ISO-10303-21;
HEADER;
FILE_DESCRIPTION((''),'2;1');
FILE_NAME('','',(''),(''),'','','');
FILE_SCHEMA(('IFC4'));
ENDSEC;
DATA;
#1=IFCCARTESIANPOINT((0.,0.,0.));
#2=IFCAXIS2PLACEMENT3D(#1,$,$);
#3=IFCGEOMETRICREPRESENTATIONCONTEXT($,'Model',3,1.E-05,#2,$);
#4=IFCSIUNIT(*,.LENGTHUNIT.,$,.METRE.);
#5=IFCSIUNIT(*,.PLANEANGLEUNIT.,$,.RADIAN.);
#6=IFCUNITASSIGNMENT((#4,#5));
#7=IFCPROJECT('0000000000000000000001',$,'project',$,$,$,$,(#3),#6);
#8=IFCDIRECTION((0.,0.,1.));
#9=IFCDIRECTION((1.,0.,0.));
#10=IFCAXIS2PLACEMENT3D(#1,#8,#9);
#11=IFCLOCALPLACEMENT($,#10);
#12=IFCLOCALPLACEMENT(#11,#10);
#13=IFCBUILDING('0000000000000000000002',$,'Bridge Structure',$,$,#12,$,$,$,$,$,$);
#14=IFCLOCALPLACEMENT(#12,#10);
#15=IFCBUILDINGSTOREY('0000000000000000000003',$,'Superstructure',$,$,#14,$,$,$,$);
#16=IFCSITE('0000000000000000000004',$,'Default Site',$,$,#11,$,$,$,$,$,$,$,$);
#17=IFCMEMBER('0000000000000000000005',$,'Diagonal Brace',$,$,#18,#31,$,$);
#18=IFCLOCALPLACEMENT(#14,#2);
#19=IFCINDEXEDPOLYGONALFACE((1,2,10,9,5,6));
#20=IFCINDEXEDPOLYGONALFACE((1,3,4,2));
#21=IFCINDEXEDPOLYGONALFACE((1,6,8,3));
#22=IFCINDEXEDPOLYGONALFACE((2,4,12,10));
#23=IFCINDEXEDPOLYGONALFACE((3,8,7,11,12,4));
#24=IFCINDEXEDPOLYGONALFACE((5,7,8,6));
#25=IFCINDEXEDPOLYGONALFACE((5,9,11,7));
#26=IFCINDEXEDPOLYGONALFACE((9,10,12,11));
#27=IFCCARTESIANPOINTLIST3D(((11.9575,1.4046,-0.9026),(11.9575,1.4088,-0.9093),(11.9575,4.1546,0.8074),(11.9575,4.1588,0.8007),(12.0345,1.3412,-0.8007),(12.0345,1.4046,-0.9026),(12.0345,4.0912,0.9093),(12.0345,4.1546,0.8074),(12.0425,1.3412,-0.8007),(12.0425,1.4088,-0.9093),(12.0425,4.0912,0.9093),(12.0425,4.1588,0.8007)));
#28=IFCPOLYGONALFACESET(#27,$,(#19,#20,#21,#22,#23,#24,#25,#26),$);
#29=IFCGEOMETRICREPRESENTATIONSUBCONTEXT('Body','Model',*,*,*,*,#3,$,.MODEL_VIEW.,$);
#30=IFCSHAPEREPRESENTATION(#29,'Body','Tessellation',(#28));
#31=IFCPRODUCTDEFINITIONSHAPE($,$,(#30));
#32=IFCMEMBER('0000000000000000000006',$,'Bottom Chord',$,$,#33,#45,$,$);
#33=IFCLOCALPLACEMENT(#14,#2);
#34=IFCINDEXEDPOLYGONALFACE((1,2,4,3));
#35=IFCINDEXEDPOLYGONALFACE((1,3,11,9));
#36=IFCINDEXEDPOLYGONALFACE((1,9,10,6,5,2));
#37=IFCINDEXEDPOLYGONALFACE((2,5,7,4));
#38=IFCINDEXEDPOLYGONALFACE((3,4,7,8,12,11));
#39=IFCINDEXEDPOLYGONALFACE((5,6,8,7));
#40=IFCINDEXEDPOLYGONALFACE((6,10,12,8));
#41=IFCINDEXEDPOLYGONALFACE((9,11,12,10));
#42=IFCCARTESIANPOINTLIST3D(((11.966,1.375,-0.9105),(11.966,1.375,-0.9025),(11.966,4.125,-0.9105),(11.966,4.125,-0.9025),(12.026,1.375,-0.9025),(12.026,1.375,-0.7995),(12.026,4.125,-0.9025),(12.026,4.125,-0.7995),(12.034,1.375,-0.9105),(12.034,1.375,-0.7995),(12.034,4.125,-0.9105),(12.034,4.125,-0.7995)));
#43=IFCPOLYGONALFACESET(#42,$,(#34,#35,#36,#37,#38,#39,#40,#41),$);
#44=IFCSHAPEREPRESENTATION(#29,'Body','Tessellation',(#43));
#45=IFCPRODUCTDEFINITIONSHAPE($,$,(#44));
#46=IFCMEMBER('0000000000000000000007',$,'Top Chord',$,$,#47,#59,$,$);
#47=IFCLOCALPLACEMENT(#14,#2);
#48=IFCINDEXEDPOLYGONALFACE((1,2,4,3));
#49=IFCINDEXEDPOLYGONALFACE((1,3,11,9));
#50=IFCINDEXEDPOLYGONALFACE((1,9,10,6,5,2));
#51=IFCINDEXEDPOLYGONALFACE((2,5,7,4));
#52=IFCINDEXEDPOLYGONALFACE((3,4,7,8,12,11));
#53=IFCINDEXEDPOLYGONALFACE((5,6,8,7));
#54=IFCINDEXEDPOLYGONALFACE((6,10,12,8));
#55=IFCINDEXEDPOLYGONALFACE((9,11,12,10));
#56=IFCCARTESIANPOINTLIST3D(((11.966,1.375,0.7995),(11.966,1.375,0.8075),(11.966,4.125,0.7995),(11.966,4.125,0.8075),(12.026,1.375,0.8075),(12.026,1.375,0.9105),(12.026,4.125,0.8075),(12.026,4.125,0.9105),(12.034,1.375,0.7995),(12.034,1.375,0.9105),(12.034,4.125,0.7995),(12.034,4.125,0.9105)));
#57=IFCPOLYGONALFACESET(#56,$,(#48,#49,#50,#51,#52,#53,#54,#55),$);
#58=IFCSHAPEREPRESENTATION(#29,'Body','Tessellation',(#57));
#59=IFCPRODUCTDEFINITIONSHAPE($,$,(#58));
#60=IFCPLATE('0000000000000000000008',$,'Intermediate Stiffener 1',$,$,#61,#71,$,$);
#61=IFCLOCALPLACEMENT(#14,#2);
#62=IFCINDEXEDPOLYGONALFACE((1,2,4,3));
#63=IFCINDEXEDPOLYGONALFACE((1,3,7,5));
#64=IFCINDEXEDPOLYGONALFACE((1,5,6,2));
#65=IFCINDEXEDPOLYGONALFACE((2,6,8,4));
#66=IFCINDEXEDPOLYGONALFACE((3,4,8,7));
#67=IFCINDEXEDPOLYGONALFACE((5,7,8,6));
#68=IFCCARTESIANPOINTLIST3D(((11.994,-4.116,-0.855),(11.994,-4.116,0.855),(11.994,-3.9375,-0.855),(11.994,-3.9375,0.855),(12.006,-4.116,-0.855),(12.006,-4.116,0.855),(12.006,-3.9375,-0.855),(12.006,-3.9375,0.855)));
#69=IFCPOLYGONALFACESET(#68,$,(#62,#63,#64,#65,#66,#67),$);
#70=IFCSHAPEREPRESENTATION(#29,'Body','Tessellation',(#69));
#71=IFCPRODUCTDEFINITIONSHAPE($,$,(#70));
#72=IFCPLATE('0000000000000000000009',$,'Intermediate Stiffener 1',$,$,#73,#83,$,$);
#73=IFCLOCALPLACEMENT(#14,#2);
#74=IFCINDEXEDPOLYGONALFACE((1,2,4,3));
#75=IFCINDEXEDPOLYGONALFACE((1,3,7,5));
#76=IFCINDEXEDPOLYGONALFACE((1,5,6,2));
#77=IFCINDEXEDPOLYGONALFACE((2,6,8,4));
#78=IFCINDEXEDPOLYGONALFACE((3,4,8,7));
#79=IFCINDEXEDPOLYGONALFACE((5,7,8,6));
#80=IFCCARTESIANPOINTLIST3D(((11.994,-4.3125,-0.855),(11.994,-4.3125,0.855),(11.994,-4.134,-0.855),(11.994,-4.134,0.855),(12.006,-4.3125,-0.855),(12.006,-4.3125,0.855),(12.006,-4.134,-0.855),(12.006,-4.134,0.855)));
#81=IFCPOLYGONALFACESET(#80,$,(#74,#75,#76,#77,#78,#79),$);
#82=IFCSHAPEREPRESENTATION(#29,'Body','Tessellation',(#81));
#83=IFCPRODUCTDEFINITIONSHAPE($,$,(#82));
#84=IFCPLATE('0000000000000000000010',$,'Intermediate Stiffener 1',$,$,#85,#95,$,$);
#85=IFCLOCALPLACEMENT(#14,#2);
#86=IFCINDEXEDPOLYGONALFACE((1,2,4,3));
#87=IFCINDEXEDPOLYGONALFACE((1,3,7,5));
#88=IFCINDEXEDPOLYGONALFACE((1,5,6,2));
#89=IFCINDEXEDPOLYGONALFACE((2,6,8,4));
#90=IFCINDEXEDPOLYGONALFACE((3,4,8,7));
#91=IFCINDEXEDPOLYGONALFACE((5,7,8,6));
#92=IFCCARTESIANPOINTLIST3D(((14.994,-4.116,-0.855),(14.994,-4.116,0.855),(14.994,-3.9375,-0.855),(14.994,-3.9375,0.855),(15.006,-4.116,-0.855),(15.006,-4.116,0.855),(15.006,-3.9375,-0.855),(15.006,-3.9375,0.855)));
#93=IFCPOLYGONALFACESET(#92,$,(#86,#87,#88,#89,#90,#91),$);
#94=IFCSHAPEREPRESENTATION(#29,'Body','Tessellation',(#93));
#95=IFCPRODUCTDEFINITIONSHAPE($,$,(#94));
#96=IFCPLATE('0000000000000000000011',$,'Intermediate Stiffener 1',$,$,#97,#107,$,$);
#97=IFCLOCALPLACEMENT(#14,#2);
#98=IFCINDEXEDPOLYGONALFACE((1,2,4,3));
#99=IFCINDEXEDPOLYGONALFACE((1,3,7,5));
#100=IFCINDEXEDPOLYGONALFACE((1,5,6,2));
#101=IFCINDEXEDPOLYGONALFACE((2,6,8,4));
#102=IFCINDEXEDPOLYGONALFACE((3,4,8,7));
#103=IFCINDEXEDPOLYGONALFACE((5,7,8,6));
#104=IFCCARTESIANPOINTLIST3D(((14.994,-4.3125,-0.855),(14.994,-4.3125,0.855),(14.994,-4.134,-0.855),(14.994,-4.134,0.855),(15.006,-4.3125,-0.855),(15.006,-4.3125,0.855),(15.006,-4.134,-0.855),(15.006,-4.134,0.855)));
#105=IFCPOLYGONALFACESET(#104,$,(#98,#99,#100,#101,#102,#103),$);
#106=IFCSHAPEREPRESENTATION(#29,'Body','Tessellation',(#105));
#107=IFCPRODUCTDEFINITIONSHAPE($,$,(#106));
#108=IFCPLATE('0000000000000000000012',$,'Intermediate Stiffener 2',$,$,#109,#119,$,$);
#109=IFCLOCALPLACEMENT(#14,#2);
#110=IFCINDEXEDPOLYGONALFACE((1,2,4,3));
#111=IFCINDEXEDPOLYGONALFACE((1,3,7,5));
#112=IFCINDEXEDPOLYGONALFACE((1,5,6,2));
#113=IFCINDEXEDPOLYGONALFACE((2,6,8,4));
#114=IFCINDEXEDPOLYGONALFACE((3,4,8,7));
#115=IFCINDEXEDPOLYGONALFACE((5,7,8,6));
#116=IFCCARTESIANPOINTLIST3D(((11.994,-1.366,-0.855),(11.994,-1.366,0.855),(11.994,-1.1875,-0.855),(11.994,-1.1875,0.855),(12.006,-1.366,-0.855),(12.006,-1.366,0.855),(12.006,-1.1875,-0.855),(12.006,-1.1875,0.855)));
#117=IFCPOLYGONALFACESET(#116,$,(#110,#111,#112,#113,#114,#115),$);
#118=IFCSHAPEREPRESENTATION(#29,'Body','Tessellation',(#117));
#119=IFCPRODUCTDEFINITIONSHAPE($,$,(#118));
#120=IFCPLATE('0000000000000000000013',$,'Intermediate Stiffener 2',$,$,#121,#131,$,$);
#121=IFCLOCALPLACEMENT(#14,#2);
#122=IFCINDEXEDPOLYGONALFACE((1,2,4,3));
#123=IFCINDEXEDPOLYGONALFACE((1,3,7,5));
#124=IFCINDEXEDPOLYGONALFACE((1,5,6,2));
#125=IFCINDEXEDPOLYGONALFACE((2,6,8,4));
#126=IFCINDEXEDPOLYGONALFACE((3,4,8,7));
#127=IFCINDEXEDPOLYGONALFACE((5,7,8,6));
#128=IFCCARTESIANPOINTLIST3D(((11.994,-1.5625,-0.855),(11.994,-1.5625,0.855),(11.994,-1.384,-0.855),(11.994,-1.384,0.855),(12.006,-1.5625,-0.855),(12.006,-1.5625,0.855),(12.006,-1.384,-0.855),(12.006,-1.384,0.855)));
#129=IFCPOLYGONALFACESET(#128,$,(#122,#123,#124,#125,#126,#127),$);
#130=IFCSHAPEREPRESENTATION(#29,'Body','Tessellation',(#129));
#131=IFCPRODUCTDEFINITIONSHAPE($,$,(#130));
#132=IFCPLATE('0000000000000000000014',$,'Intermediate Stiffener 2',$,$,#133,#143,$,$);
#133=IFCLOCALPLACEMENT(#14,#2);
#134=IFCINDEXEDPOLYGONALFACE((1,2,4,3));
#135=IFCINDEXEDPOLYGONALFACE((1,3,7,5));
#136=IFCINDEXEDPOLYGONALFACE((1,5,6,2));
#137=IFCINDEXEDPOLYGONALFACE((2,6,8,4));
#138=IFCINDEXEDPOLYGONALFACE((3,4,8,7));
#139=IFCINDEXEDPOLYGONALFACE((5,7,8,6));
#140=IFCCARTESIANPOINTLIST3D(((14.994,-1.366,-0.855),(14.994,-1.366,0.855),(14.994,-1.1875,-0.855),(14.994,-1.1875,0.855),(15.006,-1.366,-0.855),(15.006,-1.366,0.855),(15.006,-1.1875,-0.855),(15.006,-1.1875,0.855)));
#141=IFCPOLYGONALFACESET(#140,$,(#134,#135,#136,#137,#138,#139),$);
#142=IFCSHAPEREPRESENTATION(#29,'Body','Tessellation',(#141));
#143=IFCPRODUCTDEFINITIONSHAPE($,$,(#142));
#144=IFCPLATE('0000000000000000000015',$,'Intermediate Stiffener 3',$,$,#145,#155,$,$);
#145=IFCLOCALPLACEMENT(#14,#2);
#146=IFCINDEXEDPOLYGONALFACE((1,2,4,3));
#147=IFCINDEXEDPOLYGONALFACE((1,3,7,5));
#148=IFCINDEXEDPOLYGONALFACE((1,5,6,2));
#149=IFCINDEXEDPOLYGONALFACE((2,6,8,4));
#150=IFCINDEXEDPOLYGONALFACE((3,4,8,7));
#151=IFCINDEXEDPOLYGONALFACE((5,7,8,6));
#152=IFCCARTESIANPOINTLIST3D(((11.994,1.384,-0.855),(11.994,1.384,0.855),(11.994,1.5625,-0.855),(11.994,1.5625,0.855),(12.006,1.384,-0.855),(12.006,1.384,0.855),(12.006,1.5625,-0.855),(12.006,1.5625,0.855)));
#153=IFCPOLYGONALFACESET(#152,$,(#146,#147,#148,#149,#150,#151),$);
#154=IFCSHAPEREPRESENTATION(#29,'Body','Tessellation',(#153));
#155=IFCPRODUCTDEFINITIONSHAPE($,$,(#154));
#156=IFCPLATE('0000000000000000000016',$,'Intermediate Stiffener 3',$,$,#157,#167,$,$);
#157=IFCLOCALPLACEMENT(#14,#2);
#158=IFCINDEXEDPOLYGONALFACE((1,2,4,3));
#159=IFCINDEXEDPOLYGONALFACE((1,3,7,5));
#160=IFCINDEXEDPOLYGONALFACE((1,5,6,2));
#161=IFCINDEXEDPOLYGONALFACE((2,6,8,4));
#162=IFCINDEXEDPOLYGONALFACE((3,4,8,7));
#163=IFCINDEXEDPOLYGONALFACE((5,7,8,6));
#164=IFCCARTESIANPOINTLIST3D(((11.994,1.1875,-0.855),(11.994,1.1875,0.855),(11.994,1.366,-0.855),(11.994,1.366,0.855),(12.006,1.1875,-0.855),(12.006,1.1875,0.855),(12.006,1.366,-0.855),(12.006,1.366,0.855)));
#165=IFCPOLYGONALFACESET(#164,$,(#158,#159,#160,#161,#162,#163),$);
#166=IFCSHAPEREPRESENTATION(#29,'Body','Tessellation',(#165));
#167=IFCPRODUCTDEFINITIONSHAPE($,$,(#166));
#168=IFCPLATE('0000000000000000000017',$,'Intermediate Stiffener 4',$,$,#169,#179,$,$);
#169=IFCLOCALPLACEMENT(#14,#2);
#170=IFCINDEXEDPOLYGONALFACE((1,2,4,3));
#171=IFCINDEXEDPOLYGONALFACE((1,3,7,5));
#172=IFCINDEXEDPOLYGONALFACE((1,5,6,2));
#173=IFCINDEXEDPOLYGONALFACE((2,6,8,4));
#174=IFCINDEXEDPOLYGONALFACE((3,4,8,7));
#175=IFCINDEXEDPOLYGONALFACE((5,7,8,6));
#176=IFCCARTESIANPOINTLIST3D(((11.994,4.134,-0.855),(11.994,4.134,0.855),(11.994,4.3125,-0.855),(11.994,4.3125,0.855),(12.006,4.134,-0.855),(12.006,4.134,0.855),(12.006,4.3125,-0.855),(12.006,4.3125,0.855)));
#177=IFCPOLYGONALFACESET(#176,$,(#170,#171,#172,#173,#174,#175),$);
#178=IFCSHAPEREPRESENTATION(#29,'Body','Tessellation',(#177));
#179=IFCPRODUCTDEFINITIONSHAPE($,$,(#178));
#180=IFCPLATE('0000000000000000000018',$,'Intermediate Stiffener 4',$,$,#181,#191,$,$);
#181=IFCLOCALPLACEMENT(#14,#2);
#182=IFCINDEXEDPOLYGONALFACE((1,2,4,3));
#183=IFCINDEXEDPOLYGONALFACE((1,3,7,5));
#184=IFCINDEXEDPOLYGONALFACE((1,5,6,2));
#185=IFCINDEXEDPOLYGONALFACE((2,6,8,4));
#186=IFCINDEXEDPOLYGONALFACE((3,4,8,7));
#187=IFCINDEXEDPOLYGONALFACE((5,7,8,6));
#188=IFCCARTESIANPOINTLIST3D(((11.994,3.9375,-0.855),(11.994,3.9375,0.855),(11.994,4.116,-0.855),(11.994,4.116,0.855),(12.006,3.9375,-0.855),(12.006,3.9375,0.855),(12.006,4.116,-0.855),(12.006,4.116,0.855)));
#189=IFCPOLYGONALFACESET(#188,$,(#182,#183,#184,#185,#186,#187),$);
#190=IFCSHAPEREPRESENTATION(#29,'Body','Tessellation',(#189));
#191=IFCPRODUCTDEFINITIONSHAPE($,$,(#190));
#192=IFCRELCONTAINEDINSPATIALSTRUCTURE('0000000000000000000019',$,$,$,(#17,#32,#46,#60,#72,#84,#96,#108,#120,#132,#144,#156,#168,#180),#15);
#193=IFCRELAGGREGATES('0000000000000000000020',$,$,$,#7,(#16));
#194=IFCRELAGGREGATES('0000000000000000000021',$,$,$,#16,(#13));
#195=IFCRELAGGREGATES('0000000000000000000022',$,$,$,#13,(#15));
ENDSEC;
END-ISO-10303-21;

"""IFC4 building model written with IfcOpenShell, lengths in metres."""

from ifc_helpers import new_model, si_unit, frame, origin, origin_with_axes, origin_2d_with_axis, place, context, subcontext, project, spatial, rectangle, l_section, extrude, element, save


model = new_model("IFC4")

# Units and contexts
model_context = context("Model", 3, precision=1e-05, world=origin())
body_context = subcontext(model_context, "Body", "Model", "MODEL_VIEW")
ifc_project = project(units=[si_unit("LENGTHUNIT", "METRE"), si_unit("PLANEANGLEUNIT", "RADIAN")], contexts=[model_context])

# Site, building, storey
site_placement = place(None, origin_with_axes())
site = spatial("IfcSite", under=ifc_project, at=site_placement, Name="Default Site")
building_placement = place(site_placement, origin_with_axes())
building = spatial("IfcBuilding", under=site, at=building_placement, Name="Bridge Structure")
storey_placement = place(building_placement, origin_with_axes())
storey = spatial("IfcBuildingStorey", under=building, at=storey_placement, Name="Superstructure")

# Members
for number, where, z_axis, x_axis, name in (
    (1, (12.0, 1.375, -0.855), (0.0, 0.84921, 0.528055), (-1.0, 0.0, 0.0), "Diagonal Brace"),
):
    element("IfcMember", number, at=place(storey_placement, frame(where, z_axis=z_axis, x_axis=x_axis)), inside=storey, Name=name, context=body_context, shape_type="SweptSolid", body=[
        extrude(l_section(Depth=0.128, Width=0.085, Thickness=0.008, at=origin_2d_with_axis()), origin_with_axes(), (0.0, 0.0, 1.0), 3.2383),
    ])
for number, where, z_axis, x_axis, name in (
    (2, (12.0, 1.375, -0.855), (0.0, 1.0, 0.0), (-1.0, 0.0, 0.0), "Bottom Chord"),
    (3, (12.0, 1.375, 0.855), (0.0, 1.0, 0.0), (-1.0, 0.0, 0.0), "Top Chord"),
):
    element("IfcMember", number, at=place(storey_placement, frame(where, z_axis=z_axis, x_axis=x_axis)), inside=storey, Name=name, context=body_context, shape_type="SweptSolid", body=[
        extrude(l_section(Depth=0.111, Width=0.068, Thickness=0.008, at=origin_2d_with_axis()), origin_with_axes(), (0.0, 0.0, 1.0), 2.75),
    ])

# Plates
for number, where, z_axis, x_axis, name in (
    (4, (12.0, -4.0267, -0.855), (0.0, 0.0, 1.0), (1.0, 0.0, 0.0), "Intermediate Stiffener 1"),
    (5, (12.0, -4.2233, -0.855), (0.0, 0.0, 1.0), (1.0, 0.0, 0.0), "Intermediate Stiffener 1"),
    (6, (15.0, -4.0267, -0.855), (0.0, 0.0, 1.0), (1.0, 0.0, 0.0), "Intermediate Stiffener 1"),
    (7, (15.0, -4.2233, -0.855), (0.0, 0.0, 1.0), (1.0, 0.0, 0.0), "Intermediate Stiffener 1"),
    (8, (12.0, -1.2768, -0.855), (0.0, 0.0, 1.0), (1.0, 0.0, 0.0), "Intermediate Stiffener 2"),
    (9, (12.0, -1.4732, -0.855), (0.0, 0.0, 1.0), (1.0, 0.0, 0.0), "Intermediate Stiffener 2"),
    (10, (15.0, -1.2768, -0.855), (0.0, 0.0, 1.0), (1.0, 0.0, 0.0), "Intermediate Stiffener 2"),
    (11, (12.0, 1.4732, -0.855), (0.0, 0.0, 1.0), (1.0, 0.0, 0.0), "Intermediate Stiffener 3"),
    (12, (12.0, 1.2768, -0.855), (0.0, 0.0, 1.0), (1.0, 0.0, 0.0), "Intermediate Stiffener 3"),
    (13, (12.0, 4.2233, -0.855), (0.0, 0.0, 1.0), (1.0, 0.0, 0.0), "Intermediate Stiffener 4"),
    (14, (12.0, 4.0267, -0.855), (0.0, 0.0, 1.0), (1.0, 0.0, 0.0), "Intermediate Stiffener 4"),
):
    element("IfcPlate", number, at=place(storey_placement, frame(where, z_axis=z_axis, x_axis=x_axis)), inside=storey, Name=name, context=body_context, shape_type="SweptSolid", body=[
        extrude(rectangle(XDim=0.012, YDim=0.1785, at=origin_2d_with_axis()), origin_with_axes(), (0.0, 0.0, 1.0), 1.71),
    ])

save(model, "model.ifc")
